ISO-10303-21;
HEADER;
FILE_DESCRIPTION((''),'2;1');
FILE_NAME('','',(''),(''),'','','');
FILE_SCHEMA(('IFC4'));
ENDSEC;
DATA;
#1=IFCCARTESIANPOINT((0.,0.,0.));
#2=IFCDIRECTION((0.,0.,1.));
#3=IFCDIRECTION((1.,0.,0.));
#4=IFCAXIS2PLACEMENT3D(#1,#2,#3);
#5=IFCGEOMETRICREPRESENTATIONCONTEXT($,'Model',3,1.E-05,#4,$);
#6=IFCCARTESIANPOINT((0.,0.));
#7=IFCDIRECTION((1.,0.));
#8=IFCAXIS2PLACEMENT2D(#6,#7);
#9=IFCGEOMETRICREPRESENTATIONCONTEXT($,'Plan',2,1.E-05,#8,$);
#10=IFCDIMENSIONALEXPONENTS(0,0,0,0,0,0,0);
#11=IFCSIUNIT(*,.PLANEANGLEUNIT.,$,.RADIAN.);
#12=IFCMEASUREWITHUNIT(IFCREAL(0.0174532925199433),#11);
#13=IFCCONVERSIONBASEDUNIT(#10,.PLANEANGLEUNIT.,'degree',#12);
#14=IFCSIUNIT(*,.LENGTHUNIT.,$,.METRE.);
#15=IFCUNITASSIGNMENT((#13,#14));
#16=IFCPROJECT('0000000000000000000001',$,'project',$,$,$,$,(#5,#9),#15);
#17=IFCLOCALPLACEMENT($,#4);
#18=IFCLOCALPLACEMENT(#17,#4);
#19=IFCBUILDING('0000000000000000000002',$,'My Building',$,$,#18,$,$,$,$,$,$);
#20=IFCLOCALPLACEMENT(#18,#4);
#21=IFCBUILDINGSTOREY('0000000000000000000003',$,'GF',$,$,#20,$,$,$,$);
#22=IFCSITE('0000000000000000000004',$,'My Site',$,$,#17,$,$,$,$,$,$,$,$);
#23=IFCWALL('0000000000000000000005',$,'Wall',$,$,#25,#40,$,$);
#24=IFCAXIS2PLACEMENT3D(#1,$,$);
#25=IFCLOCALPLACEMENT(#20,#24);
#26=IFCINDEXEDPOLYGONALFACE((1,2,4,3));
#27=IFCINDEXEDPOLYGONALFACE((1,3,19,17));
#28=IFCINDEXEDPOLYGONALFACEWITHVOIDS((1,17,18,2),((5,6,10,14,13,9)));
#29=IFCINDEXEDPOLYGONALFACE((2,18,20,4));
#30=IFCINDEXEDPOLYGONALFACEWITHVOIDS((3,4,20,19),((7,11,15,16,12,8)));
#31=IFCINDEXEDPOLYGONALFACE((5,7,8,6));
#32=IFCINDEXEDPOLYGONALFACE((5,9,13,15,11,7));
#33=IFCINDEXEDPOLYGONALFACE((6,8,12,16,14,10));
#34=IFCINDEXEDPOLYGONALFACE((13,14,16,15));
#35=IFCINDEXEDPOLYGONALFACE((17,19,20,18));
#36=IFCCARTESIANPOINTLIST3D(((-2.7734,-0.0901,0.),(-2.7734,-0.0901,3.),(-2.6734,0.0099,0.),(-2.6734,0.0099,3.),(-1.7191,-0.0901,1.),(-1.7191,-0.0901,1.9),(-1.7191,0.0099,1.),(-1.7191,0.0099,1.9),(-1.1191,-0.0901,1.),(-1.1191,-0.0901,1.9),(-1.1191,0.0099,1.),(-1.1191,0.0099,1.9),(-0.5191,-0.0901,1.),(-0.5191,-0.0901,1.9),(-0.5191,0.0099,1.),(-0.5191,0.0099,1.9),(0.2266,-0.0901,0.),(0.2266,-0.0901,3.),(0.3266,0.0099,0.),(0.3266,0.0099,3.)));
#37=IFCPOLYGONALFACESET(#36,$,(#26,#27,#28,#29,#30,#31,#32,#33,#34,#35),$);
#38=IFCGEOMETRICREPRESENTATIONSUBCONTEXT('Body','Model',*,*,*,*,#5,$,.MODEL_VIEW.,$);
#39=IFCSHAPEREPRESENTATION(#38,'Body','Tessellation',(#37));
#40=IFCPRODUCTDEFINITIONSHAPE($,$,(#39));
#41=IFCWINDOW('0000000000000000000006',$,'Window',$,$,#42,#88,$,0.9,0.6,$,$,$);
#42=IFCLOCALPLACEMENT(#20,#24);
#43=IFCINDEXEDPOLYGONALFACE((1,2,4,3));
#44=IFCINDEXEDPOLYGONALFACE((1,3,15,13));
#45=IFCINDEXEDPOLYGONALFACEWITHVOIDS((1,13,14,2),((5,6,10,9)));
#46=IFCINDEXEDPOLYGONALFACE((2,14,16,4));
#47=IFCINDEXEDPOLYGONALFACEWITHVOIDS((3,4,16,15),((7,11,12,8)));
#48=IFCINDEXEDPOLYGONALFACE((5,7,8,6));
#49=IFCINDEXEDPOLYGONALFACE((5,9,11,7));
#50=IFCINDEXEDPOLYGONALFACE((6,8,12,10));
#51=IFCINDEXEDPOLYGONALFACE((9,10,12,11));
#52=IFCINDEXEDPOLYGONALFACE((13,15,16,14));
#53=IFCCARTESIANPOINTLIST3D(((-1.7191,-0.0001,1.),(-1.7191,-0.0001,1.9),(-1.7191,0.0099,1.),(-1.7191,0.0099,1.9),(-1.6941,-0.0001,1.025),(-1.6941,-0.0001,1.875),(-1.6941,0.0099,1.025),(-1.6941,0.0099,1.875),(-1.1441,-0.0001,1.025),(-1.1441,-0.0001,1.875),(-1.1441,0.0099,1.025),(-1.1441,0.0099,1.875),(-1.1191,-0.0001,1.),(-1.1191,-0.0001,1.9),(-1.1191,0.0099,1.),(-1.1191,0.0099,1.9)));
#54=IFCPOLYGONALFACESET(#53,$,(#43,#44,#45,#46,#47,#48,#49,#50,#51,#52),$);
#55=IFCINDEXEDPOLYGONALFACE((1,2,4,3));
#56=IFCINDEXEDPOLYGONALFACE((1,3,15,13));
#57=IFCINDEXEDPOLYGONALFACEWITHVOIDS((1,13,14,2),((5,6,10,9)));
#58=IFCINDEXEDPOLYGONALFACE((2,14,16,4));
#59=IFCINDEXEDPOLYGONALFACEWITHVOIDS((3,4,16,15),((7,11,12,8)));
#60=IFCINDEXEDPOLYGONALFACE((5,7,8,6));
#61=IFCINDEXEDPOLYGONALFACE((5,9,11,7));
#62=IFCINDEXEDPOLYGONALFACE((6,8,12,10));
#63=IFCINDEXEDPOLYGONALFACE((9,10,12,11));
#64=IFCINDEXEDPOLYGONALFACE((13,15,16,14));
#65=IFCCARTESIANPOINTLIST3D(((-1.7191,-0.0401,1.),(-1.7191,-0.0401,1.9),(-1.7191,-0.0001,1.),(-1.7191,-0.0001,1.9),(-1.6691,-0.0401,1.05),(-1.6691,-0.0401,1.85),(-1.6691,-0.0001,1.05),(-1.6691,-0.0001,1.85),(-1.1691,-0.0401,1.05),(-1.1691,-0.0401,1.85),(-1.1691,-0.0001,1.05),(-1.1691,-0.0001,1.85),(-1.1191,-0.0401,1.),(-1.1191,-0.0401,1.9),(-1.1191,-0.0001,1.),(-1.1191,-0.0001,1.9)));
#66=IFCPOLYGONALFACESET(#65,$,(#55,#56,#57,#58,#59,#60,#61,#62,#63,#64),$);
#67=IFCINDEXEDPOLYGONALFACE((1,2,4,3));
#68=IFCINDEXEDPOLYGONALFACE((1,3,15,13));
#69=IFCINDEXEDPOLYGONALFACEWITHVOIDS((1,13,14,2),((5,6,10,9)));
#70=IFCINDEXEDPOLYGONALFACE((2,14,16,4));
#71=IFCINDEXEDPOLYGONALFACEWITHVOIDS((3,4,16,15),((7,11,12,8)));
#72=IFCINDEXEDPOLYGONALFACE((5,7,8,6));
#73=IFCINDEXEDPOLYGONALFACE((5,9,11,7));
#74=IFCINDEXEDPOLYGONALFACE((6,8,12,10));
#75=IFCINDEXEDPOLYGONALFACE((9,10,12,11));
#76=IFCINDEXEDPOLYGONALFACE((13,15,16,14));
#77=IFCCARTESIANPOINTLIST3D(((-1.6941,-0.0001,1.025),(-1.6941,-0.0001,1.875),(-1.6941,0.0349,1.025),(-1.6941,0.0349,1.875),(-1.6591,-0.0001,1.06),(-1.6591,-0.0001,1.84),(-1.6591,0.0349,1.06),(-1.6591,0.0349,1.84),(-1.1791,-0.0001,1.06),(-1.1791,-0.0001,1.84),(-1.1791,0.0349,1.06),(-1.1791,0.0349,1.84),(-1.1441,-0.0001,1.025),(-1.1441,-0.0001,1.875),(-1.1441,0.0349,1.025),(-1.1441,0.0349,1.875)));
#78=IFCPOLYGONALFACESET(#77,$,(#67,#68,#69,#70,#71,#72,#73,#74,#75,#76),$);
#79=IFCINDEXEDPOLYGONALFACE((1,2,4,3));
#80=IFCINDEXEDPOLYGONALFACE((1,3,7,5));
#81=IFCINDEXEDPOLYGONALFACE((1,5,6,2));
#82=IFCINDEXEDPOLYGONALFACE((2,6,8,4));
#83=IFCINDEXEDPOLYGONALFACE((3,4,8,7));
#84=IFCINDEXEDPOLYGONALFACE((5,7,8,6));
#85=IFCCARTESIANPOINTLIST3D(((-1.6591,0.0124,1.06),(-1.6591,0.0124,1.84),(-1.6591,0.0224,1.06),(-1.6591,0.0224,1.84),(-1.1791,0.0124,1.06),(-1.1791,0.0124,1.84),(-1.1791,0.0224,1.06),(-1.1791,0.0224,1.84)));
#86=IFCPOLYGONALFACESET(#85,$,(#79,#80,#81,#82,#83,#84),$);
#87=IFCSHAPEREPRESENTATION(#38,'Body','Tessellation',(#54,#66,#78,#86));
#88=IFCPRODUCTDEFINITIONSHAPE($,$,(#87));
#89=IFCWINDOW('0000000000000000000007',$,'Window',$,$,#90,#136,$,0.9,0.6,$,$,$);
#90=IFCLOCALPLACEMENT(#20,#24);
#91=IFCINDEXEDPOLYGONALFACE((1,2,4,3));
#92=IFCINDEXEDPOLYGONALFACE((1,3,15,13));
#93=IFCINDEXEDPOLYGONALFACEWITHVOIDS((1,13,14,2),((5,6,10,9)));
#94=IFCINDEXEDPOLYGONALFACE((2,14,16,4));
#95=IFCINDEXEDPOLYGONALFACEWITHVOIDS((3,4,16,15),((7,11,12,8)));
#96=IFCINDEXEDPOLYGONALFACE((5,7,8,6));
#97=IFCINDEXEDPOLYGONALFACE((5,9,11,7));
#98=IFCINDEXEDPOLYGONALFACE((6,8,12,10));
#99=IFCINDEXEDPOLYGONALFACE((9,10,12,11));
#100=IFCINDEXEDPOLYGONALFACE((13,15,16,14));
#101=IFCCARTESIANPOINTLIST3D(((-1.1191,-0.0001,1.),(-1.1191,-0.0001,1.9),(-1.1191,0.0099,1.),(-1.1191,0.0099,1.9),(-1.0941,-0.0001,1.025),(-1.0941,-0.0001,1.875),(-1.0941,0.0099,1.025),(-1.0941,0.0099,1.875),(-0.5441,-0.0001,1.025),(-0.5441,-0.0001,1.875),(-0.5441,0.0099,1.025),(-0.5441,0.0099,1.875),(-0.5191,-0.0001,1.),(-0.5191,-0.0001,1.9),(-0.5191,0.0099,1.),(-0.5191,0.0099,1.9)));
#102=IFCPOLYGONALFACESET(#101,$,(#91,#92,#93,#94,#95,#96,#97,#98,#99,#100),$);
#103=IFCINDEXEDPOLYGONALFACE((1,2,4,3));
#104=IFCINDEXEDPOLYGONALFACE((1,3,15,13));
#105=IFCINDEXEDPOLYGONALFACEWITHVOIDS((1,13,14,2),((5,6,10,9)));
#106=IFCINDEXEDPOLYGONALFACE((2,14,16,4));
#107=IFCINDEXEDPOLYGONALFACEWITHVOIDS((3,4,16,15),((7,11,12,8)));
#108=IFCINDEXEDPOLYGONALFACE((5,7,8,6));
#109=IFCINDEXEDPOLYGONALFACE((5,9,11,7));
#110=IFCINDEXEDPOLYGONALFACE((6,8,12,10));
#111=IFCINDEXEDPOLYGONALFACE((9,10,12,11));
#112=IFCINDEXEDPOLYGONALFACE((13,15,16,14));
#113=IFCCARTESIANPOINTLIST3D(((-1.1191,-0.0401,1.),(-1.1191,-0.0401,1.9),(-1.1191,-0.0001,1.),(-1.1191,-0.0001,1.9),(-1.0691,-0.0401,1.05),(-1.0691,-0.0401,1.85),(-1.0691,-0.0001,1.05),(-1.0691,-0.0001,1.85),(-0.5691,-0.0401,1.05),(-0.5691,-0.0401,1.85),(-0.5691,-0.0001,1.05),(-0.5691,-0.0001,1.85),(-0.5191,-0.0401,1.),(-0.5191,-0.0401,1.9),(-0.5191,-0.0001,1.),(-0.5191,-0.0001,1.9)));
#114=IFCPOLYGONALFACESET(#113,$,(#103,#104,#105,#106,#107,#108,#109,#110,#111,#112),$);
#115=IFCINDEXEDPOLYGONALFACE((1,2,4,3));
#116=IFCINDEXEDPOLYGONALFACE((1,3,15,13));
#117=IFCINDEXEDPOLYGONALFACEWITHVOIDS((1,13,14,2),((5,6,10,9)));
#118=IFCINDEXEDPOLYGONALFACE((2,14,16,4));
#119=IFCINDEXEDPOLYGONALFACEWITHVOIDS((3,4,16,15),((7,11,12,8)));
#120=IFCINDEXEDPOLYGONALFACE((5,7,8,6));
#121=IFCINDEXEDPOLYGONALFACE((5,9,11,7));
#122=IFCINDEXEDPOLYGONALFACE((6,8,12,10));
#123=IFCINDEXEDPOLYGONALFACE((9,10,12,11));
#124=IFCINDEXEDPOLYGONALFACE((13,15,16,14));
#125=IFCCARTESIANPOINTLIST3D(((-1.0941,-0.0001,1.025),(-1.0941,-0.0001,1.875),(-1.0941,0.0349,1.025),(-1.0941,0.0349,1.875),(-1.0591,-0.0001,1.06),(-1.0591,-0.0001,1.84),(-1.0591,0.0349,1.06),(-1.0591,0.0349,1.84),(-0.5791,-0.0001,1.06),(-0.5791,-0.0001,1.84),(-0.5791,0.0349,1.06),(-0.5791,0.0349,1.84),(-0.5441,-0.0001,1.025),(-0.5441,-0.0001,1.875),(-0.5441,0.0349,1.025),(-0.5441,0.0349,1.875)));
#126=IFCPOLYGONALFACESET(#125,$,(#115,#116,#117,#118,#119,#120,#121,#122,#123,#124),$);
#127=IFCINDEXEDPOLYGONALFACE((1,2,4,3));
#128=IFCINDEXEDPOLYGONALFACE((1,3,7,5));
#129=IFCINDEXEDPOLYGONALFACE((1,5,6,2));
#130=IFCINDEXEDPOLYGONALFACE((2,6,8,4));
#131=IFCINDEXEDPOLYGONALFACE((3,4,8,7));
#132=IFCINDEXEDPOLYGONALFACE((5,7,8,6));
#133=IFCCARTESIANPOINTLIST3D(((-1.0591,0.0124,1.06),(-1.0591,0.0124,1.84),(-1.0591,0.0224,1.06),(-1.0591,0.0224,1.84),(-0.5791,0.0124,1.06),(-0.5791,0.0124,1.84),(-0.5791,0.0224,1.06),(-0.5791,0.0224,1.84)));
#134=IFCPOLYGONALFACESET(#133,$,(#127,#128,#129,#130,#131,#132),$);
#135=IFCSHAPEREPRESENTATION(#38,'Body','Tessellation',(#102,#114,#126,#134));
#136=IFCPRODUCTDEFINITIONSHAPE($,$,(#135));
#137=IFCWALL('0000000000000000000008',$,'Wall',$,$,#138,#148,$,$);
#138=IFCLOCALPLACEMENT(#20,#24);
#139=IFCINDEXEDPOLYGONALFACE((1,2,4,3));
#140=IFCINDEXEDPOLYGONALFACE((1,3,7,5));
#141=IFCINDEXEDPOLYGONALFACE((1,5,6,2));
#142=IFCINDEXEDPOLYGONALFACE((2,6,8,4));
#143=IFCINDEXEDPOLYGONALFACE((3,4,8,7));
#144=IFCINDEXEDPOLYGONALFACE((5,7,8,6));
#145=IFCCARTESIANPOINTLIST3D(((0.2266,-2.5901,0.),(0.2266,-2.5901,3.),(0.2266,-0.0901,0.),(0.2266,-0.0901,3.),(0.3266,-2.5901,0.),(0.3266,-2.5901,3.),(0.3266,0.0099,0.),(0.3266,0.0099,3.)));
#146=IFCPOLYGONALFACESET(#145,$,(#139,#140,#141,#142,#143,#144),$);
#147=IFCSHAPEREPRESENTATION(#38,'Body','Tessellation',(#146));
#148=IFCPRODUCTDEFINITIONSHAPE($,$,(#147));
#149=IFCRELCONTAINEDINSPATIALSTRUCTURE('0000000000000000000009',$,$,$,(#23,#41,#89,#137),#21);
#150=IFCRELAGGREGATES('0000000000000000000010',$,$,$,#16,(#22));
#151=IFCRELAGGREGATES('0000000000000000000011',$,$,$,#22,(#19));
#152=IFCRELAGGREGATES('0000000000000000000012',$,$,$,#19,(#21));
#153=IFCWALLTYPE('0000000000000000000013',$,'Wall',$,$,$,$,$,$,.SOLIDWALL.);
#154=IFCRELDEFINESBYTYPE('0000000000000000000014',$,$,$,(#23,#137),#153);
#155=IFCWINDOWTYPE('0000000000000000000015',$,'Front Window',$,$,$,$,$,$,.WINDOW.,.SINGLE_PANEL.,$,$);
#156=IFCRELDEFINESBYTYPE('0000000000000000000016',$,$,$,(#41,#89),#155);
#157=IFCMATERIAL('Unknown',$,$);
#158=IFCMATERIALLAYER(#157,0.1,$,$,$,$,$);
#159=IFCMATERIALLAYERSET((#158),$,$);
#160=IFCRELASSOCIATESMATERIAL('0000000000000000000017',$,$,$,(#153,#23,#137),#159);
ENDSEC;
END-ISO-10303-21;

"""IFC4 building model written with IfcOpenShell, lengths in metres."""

from ifc_helpers import new_model, entity, si_unit, converted_unit, frame, origin_with_axes, origin_2d_with_axis, place, context, subcontext, project, spatial, line, indexed_curve, outline, extrude, shape, source, transform, mapped, material, layer, layer_set, layer_usage, type_object, type_shapes, element, fill, save


model = new_model("IFC4")

# Units and contexts
model_context = context("Model", 3, precision=1e-05, world=origin_with_axes())
plan_context = context("Plan", 2, precision=1e-05, world=origin_2d_with_axis())
body_context_1 = subcontext(model_context, "Body", "Model", "MODEL_VIEW")
body_context_2 = subcontext(plan_context, "Body", "Plan", "PLAN_VIEW")
ifc_project = project(units=[converted_unit("PLANEANGLEUNIT", "degree", entity("IfcReal", 0.0174532925199433), si_unit("PLANEANGLEUNIT", "RADIAN"), dimensions=[0, 0, 0, 0, 0, 0, 0]), si_unit("LENGTHUNIT", "METRE")], contexts=[model_context, plan_context])

# Site, building, storey
site_placement = place(None, origin_with_axes())
site = spatial("IfcSite", under=ifc_project, at=site_placement, Name="My Site")
building_placement = place(site_placement, origin_with_axes())
building = spatial("IfcBuilding", under=site, at=building_placement, Name="My Building")
storey_placement = place(building_placement, origin_with_axes())
storey = spatial("IfcBuildingStorey", under=building, at=storey_placement, Name="GF")

# Shared definitions
ifc_material_1 = material(Name="Unknown")

# Shared definitions
ifc_layer_1 = layer(ifc_material_1, 0.1)
ifc_layer_set_1 = layer_set([ifc_layer_1])
wall_type = type_object("IfcWallType", Name="Wall", PredefinedType="SOLIDWALL", material=ifc_layer_set_1)
shared_shape_1 = source(origin_with_axes(), body_context_1, "Body", "SweptSolid", [
    extrude(outline(indexed_curve([(0.0, 0.0), (0.6, 0.0), (0.6, 0.9), (0.0, 0.9)], segments=[line(1, 2, 3, 4, 1)])), frame((0.0, -0.6, 0.0), z_axis=(0.0, -1.0, 0.0), x_axis=(1.0, 0.0, 0.0)), (0.0, 0.0, -1.0), 1.2),
])
window_type_1 = type_object("IfcWindowType", Name="Front Window", PartitioningType="SINGLE_PANEL", PredefinedType="WINDOW")
shared_shape_2 = source(origin_with_axes(), body_context_1, "Body", "SweptSolid", [
    extrude(outline(indexed_curve([(0.0, 0.0), (0.6, 0.0), (0.6, 0.9), (0.0, 0.9)], segments=[line(1, 2, 3, 4, 1)]), holes=[indexed_curve([(0.025, 0.025), (0.575, 0.025), (0.575, 0.875), (0.025, 0.875)], segments=[line(1, 2, 3, 4, 1)])]), frame((0.0, 0.09, 0.0), z_axis=(0.0, -1.0, 0.0), x_axis=(1.0, 0.0, 0.0)), (0.0, 0.0, -1.0), 0.01),
    extrude(outline(indexed_curve([(0.0, 0.0), (0.6, 0.0), (0.6, 0.9), (0.0, 0.9)], segments=[line(1, 2, 3, 4, 1)]), holes=[indexed_curve([(0.05, 0.05), (0.55, 0.05), (0.55, 0.85), (0.05, 0.85)], segments=[line(1, 2, 3, 4, 1)])]), frame((0.0, 0.05, 0.0), z_axis=(0.0, -1.0, 0.0), x_axis=(1.0, 0.0, 0.0)), (0.0, 0.0, -1.0), 0.04),
    extrude(outline(indexed_curve([(0.0, 0.0), (0.55, 0.0), (0.55, 0.85), (0.0, 0.85)], segments=[line(1, 2, 3, 4, 1)]), holes=[indexed_curve([(0.035, 0.035), (0.515, 0.035), (0.515, 0.815), (0.035, 0.815)], segments=[line(1, 2, 3, 4, 1)])]), frame((0.025, 0.09, 0.025), z_axis=(0.0, -1.0, 0.0), x_axis=(1.0, 0.0, 0.0)), (0.0, 0.0, -1.0), 0.035),
    extrude(outline(indexed_curve([(0.035, 0.035), (0.515, 0.035), (0.515, 0.815), (0.035, 0.815)], segments=[line(1, 2, 3, 4, 1)])), frame((0.025, 0.1025, 0.025), z_axis=(0.0, -1.0, 0.0), x_axis=(1.0, 0.0, 0.0)), (0.0, 0.0, -1.0), 0.01),
])
shared_shape_3 = source(origin_with_axes(), body_context_2, "Body", "Curve2D", [
    entity("IfcIndexedPolyCurve", entity("IfcCartesianPointList2D", [[0.05, 0.05], [0.55, 0.05]])),
    entity("IfcIndexedPolyCurve", entity("IfcCartesianPointList2D", [[0.0, 0.1], [0.025, 0.1], [0.025, 0.09], [0.05, 0.09], [0.05, 0.05], [0.0, 0.05]]), [entity("IfcLineIndex", [1, 2, 3, 4, 5, 6, 1])]),
    entity("IfcIndexedPolyCurve", entity("IfcCartesianPointList2D", [[0.6, 0.1], [0.575, 0.1], [0.575, 0.09], [0.55, 0.09], [0.55, 0.05], [0.6, 0.05]]), [entity("IfcLineIndex", [1, 2, 3, 4, 5, 6, 1])]),
    entity("IfcIndexedPolyCurve", entity("IfcCartesianPointList2D", [[0.025, 0.09], [0.06, 0.09], [0.06, 0.125], [0.025, 0.125]]), [entity("IfcLineIndex", [1, 2, 3, 4, 1])]),
    entity("IfcIndexedPolyCurve", entity("IfcCartesianPointList2D", [[0.575, 0.09], [0.54, 0.09], [0.54, 0.125], [0.575, 0.125]]), [entity("IfcLineIndex", [1, 2, 3, 4, 1])]),
    entity("IfcIndexedPolyCurve", entity("IfcCartesianPointList2D", [[0.06, 0.09], [0.54, 0.09]])),
    entity("IfcIndexedPolyCurve", entity("IfcCartesianPointList2D", [[0.06, 0.125], [0.54, 0.125]])),
    entity("IfcIndexedPolyCurve", entity("IfcCartesianPointList2D", [[0.06, 0.1075], [0.54, 0.1075]])),
])
type_shapes(window_type_1, [shared_shape_2, shared_shape_3])

# Wall, openings, windows
ifc_layer_usage_1 = layer_usage(ifc_layer_set_1, "AXIS2", "POSITIVE", 0.0)
wall_1_placement = place(storey_placement, frame((-2.7734, -0.0901, 0.0), z_axis=(0.0, 0.0, 1.0), x_axis=(1.0, 0.0, 0.0)))
wall_1 = element("IfcWall", 1, at=wall_1_placement, inside=storey, type_object=wall_type, material=ifc_layer_usage_1, Name="Wall", context=body_context_1, shape_type="SweptSolid", body=[
    extrude(outline(indexed_curve([(0.0, 0.0), (0.1, 0.1), (3.1, 0.1), (3.0, 0.0)], segments=[line(1, 2, 3, 4, 1)])), origin_with_axes(), (0.0, 0.0, 1.0), 3.0),
])
opening_1_placement = place(wall_1_placement, frame((1.0543, 0.0, 1.0), z_axis=(0.0, 0.0, 1.0), x_axis=(1.0, 0.0, 0.0)))
opening_1 = element("IfcOpeningElement", 2, at=opening_1_placement, cuts=wall_1, PredefinedType="OPENING", context=body_context_1, shape_type="MappedRepresentation", body=[
    mapped(shared_shape_1, transform((0.0, 0.0, 0.0), x_axis=(1.0, 0.0, 0.0), y_axis=(0.0, 1.0, 0.0), z_axis=(0.0, 0.0, 1.0), scale=1.0)),
])
opening_2_placement = place(wall_1_placement, frame((1.6543, 0.0, 1.0), z_axis=(0.0, 0.0, 1.0), x_axis=(1.0, 0.0, 0.0)))
opening_2 = element("IfcOpeningElement", 3, at=opening_2_placement, cuts=wall_1, PredefinedType="OPENING", context=body_context_1, shape_type="MappedRepresentation", body=[
    mapped(shared_shape_1, transform((0.0, 0.0, 0.0), x_axis=(1.0, 0.0, 0.0), y_axis=(0.0, 1.0, 0.0), z_axis=(0.0, 0.0, 1.0), scale=1.0)),
])
window_1_placement = place(opening_1_placement, origin_with_axes())
window_1 = element("IfcWindow", 4, at=window_1_placement, inside=storey, type_object=window_type_1, Name="Window", OverallHeight=0.9, OverallWidth=0.6, shapes=[
    shape(body_context_1, "Body", "MappedRepresentation", [mapped(shared_shape_2, transform((0.0, 0.0, 0.0), x_axis=(1.0, 0.0, 0.0), y_axis=(0.0, 1.0, 0.0), z_axis=(0.0, 0.0, 1.0), scale=1.0))]),
    shape(body_context_2, "Body", "MappedRepresentation", [mapped(shared_shape_3, transform((0.0, 0.0, 0.0), x_axis=(1.0, 0.0, 0.0), y_axis=(0.0, 1.0, 0.0), z_axis=(0.0, 0.0, 1.0), scale=1.0))]),
])
fill(opening_1, window_1)
window_2_placement = place(opening_2_placement, origin_with_axes())
window_2 = element("IfcWindow", 5, at=window_2_placement, inside=storey, type_object=window_type_1, Name="Window", OverallHeight=0.9, OverallWidth=0.6, shapes=[
    shape(body_context_1, "Body", "MappedRepresentation", [mapped(shared_shape_2, transform((0.0, 0.0, 0.0), x_axis=(1.0, 0.0, 0.0), y_axis=(0.0, 1.0, 0.0), z_axis=(0.0, 0.0, 1.0), scale=1.0))]),
    shape(body_context_2, "Body", "MappedRepresentation", [mapped(shared_shape_3, transform((0.0, 0.0, 0.0), x_axis=(1.0, 0.0, 0.0), y_axis=(0.0, 1.0, 0.0), z_axis=(0.0, 0.0, 1.0), scale=1.0))]),
])
fill(opening_2, window_2)

# Wall
ifc_layer_usage_2 = layer_usage(ifc_layer_set_1, "AXIS2", "POSITIVE", 0.0)
wall_2_placement = place(storey_placement, frame((0.2266, -0.0901, 0.0), z_axis=(0.0, 0.0, 1.0), x_axis=(0.0, -1.0, 0.0)))
element("IfcWall", 6, at=wall_2_placement, inside=storey, type_object=wall_type, material=ifc_layer_usage_2, Name="Wall", context=body_context_1, shape_type="SweptSolid", body=[
    extrude(outline(indexed_curve([(0.0, 0.0), (-0.1, 0.1), (2.5, 0.1), (2.5, 0.0)], segments=[line(1, 2, 3, 4, 1)])), origin_with_axes(), (0.0, 0.0, 1.0), 3.0),
])

save(model, "model.ifc")
